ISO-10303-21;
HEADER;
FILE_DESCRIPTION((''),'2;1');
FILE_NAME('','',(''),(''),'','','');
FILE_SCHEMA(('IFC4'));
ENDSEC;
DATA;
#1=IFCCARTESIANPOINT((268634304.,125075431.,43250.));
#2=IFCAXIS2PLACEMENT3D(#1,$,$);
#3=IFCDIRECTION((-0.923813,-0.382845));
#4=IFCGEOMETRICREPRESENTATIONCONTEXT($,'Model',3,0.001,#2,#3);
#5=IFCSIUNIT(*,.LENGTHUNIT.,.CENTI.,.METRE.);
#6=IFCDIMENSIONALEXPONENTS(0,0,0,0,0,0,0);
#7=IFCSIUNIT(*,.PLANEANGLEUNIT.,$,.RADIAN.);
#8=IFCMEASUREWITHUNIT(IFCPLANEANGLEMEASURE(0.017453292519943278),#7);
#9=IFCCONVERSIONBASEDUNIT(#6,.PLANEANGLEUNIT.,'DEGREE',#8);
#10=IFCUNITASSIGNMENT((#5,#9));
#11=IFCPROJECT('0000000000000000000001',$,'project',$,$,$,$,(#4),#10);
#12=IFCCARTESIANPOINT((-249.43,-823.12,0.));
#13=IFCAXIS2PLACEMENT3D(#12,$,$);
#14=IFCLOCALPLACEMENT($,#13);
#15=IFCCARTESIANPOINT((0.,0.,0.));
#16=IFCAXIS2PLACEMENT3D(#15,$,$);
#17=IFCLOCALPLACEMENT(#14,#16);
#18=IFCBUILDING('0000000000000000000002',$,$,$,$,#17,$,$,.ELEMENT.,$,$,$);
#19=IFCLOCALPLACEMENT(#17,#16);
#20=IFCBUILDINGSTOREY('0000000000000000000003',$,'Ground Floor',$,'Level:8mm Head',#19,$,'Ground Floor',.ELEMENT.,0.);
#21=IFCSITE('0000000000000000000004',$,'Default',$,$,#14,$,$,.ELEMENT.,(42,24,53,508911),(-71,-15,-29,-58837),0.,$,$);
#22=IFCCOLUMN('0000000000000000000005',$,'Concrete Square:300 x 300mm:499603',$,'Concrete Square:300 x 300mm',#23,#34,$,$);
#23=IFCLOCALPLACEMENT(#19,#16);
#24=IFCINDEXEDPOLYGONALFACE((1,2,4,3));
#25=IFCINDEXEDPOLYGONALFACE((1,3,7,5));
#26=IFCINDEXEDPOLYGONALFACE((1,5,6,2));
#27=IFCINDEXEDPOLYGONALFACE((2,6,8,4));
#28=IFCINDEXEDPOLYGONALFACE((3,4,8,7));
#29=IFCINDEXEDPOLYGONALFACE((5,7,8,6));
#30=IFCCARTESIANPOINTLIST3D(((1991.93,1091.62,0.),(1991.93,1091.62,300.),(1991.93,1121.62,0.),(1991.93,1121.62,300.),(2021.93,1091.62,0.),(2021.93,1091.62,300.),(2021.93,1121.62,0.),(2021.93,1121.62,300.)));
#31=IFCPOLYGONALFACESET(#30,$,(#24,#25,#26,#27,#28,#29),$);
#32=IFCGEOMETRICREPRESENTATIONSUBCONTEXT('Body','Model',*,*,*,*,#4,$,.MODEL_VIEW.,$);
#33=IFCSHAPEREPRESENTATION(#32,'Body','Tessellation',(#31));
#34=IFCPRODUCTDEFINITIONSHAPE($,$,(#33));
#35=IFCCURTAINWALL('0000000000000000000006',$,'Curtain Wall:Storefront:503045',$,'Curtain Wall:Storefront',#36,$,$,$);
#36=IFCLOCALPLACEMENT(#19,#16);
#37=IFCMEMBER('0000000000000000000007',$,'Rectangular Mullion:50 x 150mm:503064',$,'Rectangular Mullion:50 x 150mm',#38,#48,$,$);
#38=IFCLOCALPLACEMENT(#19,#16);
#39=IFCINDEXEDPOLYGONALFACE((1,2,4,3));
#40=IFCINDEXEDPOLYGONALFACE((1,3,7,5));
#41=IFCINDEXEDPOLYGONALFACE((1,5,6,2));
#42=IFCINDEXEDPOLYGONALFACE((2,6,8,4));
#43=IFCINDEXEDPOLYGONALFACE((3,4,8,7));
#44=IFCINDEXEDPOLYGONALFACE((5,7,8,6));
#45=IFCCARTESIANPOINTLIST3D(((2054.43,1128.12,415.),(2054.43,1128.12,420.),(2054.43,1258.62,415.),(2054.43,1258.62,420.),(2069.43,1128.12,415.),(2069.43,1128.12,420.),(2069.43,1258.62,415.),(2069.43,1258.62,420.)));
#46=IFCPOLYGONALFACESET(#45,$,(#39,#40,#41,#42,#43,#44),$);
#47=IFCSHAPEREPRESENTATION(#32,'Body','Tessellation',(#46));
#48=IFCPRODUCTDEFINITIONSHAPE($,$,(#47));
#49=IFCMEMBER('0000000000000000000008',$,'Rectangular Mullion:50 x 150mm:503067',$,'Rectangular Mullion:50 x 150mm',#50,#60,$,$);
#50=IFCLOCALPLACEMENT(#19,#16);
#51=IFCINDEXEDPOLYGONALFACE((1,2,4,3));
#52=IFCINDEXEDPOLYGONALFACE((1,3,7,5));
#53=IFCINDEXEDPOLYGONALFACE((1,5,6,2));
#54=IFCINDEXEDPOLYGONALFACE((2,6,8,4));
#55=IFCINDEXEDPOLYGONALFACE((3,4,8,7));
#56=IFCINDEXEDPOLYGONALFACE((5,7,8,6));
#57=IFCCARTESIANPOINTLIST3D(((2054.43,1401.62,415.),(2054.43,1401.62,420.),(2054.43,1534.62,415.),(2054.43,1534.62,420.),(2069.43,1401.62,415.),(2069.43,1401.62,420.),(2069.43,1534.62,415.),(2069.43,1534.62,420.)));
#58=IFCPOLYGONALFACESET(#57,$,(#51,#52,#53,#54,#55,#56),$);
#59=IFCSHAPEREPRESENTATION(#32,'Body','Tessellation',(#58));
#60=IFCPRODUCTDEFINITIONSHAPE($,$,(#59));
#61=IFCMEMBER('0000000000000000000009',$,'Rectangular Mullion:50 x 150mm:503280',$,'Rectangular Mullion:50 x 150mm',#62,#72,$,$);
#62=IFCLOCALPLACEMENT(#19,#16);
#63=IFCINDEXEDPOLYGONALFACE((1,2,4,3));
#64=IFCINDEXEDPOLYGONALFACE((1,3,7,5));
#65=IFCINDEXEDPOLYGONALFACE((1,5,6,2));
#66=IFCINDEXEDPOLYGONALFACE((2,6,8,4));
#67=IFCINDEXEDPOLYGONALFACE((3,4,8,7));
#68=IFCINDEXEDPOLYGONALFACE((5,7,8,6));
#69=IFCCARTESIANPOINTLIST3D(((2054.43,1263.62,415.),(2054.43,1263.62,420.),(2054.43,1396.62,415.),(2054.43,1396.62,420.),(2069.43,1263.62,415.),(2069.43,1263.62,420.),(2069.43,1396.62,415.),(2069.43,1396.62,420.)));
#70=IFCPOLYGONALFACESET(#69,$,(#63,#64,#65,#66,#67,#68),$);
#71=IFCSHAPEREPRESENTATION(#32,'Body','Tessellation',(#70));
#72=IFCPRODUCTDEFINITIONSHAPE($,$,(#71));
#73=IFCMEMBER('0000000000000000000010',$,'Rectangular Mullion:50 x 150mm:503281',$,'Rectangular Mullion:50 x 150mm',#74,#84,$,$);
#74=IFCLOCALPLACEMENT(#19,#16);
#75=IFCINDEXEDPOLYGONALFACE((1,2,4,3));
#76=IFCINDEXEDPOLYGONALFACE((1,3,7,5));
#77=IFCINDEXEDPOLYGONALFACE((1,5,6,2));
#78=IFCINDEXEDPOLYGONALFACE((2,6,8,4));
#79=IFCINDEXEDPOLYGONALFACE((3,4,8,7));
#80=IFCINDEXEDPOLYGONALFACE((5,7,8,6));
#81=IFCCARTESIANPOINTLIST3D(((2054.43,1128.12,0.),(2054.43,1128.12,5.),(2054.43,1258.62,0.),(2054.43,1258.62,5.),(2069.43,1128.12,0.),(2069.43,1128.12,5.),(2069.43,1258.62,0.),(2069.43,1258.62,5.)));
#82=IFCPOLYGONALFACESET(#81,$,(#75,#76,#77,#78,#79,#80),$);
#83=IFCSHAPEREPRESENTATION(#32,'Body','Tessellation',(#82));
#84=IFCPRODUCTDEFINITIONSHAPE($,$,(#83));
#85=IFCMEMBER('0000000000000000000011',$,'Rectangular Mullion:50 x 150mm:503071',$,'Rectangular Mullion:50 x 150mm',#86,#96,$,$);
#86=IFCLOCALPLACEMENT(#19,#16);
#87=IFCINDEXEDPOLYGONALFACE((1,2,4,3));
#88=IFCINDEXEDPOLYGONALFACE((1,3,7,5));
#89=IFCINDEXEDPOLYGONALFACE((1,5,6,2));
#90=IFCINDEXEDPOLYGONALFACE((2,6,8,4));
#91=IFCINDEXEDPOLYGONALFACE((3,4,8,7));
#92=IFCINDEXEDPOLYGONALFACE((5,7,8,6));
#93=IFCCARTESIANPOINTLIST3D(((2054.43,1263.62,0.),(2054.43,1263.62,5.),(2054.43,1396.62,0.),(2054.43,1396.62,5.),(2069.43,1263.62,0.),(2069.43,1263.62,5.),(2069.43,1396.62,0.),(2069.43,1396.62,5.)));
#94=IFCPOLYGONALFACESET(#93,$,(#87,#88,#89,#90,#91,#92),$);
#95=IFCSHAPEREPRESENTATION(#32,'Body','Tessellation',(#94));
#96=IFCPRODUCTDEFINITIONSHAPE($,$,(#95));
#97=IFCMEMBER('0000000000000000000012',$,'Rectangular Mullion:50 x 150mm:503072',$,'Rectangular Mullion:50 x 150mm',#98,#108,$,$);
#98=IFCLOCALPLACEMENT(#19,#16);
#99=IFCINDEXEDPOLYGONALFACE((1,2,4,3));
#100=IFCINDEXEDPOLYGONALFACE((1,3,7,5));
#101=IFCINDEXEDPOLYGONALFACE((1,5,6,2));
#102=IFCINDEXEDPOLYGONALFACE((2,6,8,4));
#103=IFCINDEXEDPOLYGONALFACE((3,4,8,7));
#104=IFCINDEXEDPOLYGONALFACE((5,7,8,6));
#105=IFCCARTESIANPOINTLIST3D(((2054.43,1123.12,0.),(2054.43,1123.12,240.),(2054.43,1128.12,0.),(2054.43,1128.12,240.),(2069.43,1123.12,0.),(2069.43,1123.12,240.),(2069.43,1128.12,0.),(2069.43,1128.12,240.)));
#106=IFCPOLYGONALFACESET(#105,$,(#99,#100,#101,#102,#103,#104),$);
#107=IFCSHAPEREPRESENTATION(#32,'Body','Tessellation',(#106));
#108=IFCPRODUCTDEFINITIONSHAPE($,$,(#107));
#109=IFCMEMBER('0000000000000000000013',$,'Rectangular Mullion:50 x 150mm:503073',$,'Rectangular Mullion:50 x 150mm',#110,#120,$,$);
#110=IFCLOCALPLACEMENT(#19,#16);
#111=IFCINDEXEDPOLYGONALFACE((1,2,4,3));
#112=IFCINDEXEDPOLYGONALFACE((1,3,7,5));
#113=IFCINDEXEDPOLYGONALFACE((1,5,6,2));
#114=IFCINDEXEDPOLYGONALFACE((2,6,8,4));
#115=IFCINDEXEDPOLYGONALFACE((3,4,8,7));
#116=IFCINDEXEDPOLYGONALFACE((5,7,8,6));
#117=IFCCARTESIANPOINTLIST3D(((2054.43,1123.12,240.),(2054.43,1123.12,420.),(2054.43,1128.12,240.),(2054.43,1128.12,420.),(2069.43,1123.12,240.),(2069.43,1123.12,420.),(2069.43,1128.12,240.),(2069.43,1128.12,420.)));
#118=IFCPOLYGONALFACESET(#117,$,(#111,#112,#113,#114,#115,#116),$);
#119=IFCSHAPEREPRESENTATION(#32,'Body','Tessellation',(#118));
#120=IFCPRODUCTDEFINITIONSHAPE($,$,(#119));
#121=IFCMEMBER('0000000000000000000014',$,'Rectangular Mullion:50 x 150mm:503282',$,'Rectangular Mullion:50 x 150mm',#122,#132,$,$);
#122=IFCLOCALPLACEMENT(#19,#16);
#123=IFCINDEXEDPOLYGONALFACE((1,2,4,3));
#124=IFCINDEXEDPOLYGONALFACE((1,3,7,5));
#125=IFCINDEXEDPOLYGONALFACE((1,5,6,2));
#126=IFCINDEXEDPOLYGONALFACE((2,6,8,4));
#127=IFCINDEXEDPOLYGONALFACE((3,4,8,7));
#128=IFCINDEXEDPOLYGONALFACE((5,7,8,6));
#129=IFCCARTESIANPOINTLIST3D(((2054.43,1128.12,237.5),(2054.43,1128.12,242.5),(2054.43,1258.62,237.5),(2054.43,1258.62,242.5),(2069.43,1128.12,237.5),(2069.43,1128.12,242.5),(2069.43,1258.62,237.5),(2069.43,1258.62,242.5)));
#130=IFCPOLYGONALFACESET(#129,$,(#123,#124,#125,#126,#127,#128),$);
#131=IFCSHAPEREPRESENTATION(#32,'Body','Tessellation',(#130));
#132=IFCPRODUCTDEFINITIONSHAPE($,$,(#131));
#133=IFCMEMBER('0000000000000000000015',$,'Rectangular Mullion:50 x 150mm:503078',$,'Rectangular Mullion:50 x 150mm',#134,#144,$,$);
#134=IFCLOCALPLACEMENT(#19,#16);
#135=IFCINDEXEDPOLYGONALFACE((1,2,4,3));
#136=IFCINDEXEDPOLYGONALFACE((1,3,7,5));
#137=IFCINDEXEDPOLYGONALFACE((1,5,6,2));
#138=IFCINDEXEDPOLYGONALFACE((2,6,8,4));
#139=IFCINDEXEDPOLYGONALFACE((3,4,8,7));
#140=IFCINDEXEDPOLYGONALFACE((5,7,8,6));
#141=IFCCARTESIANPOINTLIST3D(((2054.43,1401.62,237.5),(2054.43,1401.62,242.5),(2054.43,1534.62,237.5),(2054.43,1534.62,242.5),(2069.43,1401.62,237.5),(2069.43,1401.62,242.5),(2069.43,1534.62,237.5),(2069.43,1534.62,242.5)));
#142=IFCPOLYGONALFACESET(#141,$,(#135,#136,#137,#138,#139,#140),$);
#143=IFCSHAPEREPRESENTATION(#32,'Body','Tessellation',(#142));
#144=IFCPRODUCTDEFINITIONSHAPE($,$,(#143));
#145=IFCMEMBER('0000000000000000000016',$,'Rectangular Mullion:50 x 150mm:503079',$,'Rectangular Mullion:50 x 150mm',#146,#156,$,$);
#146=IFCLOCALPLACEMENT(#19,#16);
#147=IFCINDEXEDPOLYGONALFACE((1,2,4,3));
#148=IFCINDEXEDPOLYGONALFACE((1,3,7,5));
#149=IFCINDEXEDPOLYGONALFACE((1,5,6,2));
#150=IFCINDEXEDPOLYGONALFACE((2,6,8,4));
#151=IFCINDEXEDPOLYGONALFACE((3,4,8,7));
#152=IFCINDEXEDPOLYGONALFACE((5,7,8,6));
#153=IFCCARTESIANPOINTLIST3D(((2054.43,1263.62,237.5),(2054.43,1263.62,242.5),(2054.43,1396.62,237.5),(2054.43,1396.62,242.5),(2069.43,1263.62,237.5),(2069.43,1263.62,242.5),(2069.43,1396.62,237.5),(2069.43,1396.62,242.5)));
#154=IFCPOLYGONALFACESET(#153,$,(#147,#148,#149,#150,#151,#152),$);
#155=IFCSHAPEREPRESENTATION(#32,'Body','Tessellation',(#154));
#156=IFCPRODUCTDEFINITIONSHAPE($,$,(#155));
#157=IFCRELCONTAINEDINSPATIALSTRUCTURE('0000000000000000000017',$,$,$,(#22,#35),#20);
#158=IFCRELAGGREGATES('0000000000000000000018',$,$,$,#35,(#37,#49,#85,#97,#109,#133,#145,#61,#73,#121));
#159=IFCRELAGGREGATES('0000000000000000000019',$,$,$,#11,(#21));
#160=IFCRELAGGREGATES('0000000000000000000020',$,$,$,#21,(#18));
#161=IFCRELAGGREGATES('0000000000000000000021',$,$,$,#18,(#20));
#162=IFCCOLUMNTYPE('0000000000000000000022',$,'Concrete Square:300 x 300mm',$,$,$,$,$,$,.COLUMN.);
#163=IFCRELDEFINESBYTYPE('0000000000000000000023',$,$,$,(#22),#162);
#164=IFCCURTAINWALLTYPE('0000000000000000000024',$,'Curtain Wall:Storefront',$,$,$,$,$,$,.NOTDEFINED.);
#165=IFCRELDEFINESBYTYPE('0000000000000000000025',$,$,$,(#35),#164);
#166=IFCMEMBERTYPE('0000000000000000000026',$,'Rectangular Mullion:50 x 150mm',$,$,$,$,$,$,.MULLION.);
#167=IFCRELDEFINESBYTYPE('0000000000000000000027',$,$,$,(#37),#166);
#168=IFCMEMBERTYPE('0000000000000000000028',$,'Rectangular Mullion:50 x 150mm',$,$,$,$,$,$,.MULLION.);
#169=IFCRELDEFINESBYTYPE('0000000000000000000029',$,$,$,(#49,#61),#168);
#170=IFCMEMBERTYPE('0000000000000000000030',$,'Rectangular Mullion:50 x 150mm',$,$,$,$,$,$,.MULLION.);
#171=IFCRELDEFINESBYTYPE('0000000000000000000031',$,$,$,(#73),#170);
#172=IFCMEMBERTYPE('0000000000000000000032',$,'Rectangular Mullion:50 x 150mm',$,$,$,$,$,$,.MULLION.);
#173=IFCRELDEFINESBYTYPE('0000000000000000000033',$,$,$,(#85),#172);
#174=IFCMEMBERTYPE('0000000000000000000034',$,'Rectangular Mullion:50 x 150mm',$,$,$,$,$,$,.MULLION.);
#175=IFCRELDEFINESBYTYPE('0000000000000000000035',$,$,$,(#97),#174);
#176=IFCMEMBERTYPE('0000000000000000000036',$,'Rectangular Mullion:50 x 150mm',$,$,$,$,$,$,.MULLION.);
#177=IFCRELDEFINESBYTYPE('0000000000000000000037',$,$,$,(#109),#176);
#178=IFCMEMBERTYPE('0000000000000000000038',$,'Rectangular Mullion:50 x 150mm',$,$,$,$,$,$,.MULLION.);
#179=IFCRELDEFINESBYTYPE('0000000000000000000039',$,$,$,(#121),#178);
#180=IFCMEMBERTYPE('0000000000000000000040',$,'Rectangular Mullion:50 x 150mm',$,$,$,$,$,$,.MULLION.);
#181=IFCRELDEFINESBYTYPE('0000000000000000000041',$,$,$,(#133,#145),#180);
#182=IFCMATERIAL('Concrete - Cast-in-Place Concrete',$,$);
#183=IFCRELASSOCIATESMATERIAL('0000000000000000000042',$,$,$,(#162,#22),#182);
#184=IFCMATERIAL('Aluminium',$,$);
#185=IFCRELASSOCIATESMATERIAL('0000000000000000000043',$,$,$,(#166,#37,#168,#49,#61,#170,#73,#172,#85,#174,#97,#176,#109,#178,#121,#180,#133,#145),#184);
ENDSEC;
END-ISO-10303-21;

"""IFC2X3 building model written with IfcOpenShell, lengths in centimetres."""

from ifc_helpers import new_model, entity, si_unit, converted_unit, direction, frame, origin, origin_2d_with_axis, place, context, subcontext, project, spatial, rectangle, extrude, source, transform, mapped, material, type_object, type_shapes, element, aggregate, save


model = new_model("IFC2X3")

# Units and contexts
model_context = context("Model", 3, precision=0.001, world=frame((268634304.0, 125075431.0, 43250.0)), true_north=direction((-0.923813, -0.382845)))
body_context = subcontext(model_context, "Body", "Model", "MODEL_VIEW")
ifc_project = project(units=[si_unit("LENGTHUNIT", "METRE", prefix="CENTI"), converted_unit("PLANEANGLEUNIT", "DEGREE", entity("IfcPlaneAngleMeasure", 0.017453292519943278), si_unit("PLANEANGLEUNIT", "RADIAN"), dimensions=[0, 0, 0, 0, 0, 0, 0])], contexts=[model_context])

# Site, building, storey
site_placement = place(None, frame((-249.43, -823.12, 0.0)))
site = spatial("IfcSite", under=ifc_project, at=site_placement, Name="Default", CompositionType="ELEMENT", RefLatitude=(42, 24, 53, 508911), RefLongitude=(-71, -15, -29, -58837), RefElevation=0.0)
building_placement = place(site_placement, origin())
building = spatial("IfcBuilding", under=site, at=building_placement, CompositionType="ELEMENT")
storey_placement = place(building_placement, origin())
storey = spatial("IfcBuildingStorey", under=building, at=storey_placement, Name="Ground Floor", ObjectType="Level:8mm Head", LongName="Ground Floor", CompositionType="ELEMENT", Elevation=0.0)

# Column
ifc_material_1 = material(Name="Concrete - Cast-in-Place Concrete")
column_type = type_object("IfcColumnType", Name="Concrete Square:300 x 300mm", PredefinedType="COLUMN", material=ifc_material_1)
shared_shape_1 = source(origin(), body_context, "Body", "SweptSolid", [
    extrude(rectangle(XDim=30.0, YDim=30.0, at=origin_2d_with_axis()), frame((0.0, 0.0, 0.0), z_axis=(0.0, 0.0, 1.0), x_axis=(-1.0, 0.0, 0.0)), (0.0, 0.0, 1.0), 300.0),
])
type_shapes(column_type, [shared_shape_1])
column_placement = place(storey_placement, frame((2006.93, 1106.62, 0.0)))
element("IfcColumn", 1, at=column_placement, inside=storey, type_object=column_type, material=ifc_material_1, Name="Concrete Square:300 x 300mm:499603", ObjectType="Concrete Square:300 x 300mm", context=body_context, shape_type="MappedRepresentation", body=[
    mapped(shared_shape_1, transform((0.0, 0.0, 0.0), scale=1.0)),
])

# Curtain wall, members
curtain_wall_type = type_object("IfcCurtainWallType", Name="Curtain Wall:Storefront", PredefinedType="NOTDEFINED")
curtain_wall_placement = place(storey_placement, origin())
curtain_wall = element("IfcCurtainWall", 2, at=curtain_wall_placement, inside=storey, type_object=curtain_wall_type, Name="Curtain Wall:Storefront:503045", ObjectType="Curtain Wall:Storefront")
ifc_material_2 = material(Name="Aluminium")
member_type_1 = type_object("IfcMemberType", Name="Rectangular Mullion:50 x 150mm", PredefinedType="MULLION", material=ifc_material_2)
shared_shape_2 = source(origin(), body_context, "Body", "SweptSolid", [
    extrude(rectangle(XDim=5.0, YDim=15.0, at=origin_2d_with_axis()), frame((-2.5, 0.0, -130.5), z_axis=(0.0, 0.0, 1.0), x_axis=(-1.0, 0.0, 0.0)), (0.0, 0.0, 1.0), 130.5),
])
type_shapes(member_type_1, [shared_shape_2])
member_1_placement = place(curtain_wall_placement, frame((2061.93, 1128.12, 420.0), z_axis=(0.0, -1.0, 0.0), x_axis=(0.0, 0.0, 1.0)))
member_1 = element("IfcMember", 3, at=member_1_placement, type_object=member_type_1, material=ifc_material_2, Name="Rectangular Mullion:50 x 150mm:503064", ObjectType="Rectangular Mullion:50 x 150mm", context=body_context, shape_type="MappedRepresentation", body=[
    mapped(shared_shape_2, transform((0.0, 0.0, 0.0), scale=1.0)),
])
member_type_2 = type_object("IfcMemberType", Name="Rectangular Mullion:50 x 150mm", PredefinedType="MULLION", material=ifc_material_2)
shared_shape_3 = source(origin(), body_context, "Body", "SweptSolid", [
    extrude(rectangle(XDim=5.0, YDim=15.0, at=origin_2d_with_axis()), frame((-2.5, 0.0, -133.0), z_axis=(0.0, 0.0, 1.0), x_axis=(-1.0, 0.0, 0.0)), (0.0, 0.0, 1.0), 133.0),
])
type_shapes(member_type_2, [shared_shape_3])
member_2_placement = place(curtain_wall_placement, frame((2061.93, 1401.62, 420.0), z_axis=(0.0, -1.0, 0.0), x_axis=(0.0, 0.0, 1.0)))
member_2 = element("IfcMember", 4, at=member_2_placement, type_object=member_type_2, material=ifc_material_2, Name="Rectangular Mullion:50 x 150mm:503067", ObjectType="Rectangular Mullion:50 x 150mm", context=body_context, shape_type="MappedRepresentation", body=[
    mapped(shared_shape_3, transform((0.0, 0.0, 0.0), scale=1.0)),
])
member_3_placement = place(curtain_wall_placement, frame((2061.93, 1263.62, 420.0), z_axis=(0.0, -1.0, 0.0), x_axis=(0.0, 0.0, 1.0)))
member_3 = element("IfcMember", 5, at=member_3_placement, type_object=member_type_2, material=ifc_material_2, Name="Rectangular Mullion:50 x 150mm:503280", ObjectType="Rectangular Mullion:50 x 150mm", context=body_context, shape_type="MappedRepresentation", body=[
    mapped(shared_shape_3, transform((0.0, 0.0, 0.0), scale=1.0)),
])
member_type_3 = type_object("IfcMemberType", Name="Rectangular Mullion:50 x 150mm", PredefinedType="MULLION", material=ifc_material_2)
shared_shape_4 = source(origin(), body_context, "Body", "SweptSolid", [
    extrude(rectangle(XDim=5.0, YDim=15.0, at=origin_2d_with_axis()), frame((-2.5, 0.0, -130.5), z_axis=(0.0, 0.0, 1.0), x_axis=(-1.0, 0.0, 0.0)), (0.0, 0.0, 1.0), 130.5),
])
type_shapes(member_type_3, [shared_shape_4])
member_4_placement = place(curtain_wall_placement, frame((2061.93, 1258.62, 0.0), z_axis=(0.0, 1.0, 0.0), x_axis=(0.0, 0.0, -1.0)))
member_4 = element("IfcMember", 6, at=member_4_placement, type_object=member_type_3, material=ifc_material_2, Name="Rectangular Mullion:50 x 150mm:503281", ObjectType="Rectangular Mullion:50 x 150mm", context=body_context, shape_type="MappedRepresentation", body=[
    mapped(shared_shape_4, transform((0.0, 0.0, 0.0), scale=1.0)),
])
member_type_4 = type_object("IfcMemberType", Name="Rectangular Mullion:50 x 150mm", PredefinedType="MULLION", material=ifc_material_2)
shared_shape_5 = source(origin(), body_context, "Body", "SweptSolid", [
    extrude(rectangle(XDim=5.0, YDim=15.0, at=origin_2d_with_axis()), frame((-2.5, 0.0, -133.0), z_axis=(0.0, 0.0, 1.0), x_axis=(-1.0, 0.0, 0.0)), (0.0, 0.0, 1.0), 133.0),
])
type_shapes(member_type_4, [shared_shape_5])
member_5_placement = place(curtain_wall_placement, frame((2061.93, 1396.62, 0.0), z_axis=(0.0, 1.0, 0.0), x_axis=(0.0, 0.0, -1.0)))
member_5 = element("IfcMember", 7, at=member_5_placement, type_object=member_type_4, material=ifc_material_2, Name="Rectangular Mullion:50 x 150mm:503071", ObjectType="Rectangular Mullion:50 x 150mm", context=body_context, shape_type="MappedRepresentation", body=[
    mapped(shared_shape_5, transform((0.0, 0.0, 0.0), scale=1.0)),
])
member_type_5 = type_object("IfcMemberType", Name="Rectangular Mullion:50 x 150mm", PredefinedType="MULLION", material=ifc_material_2)
shared_shape_6 = source(origin(), body_context, "Body", "SweptSolid", [
    extrude(rectangle(XDim=5.0, YDim=15.0, at=origin_2d_with_axis()), frame((-2.5, 0.0, -240.0), z_axis=(0.0, 0.0, 1.0), x_axis=(-1.0, 0.0, 0.0)), (0.0, 0.0, 1.0), 240.0),
])
type_shapes(member_type_5, [shared_shape_6])
member_6_placement = place(curtain_wall_placement, frame((2061.93, 1123.12, 0.0), z_axis=(0.0, 0.0, -1.0), x_axis=(0.0, -1.0, 0.0)))
member_6 = element("IfcMember", 8, at=member_6_placement, type_object=member_type_5, material=ifc_material_2, Name="Rectangular Mullion:50 x 150mm:503072", ObjectType="Rectangular Mullion:50 x 150mm", context=body_context, shape_type="MappedRepresentation", body=[
    mapped(shared_shape_6, transform((0.0, 0.0, 0.0), scale=1.0)),
])
member_type_6 = type_object("IfcMemberType", Name="Rectangular Mullion:50 x 150mm", PredefinedType="MULLION", material=ifc_material_2)
shared_shape_7 = source(origin(), body_context, "Body", "SweptSolid", [
    extrude(rectangle(XDim=5.0, YDim=15.0, at=origin_2d_with_axis()), frame((-2.5, 0.0, -180.0), z_axis=(0.0, 0.0, 1.0), x_axis=(-1.0, 0.0, 0.0)), (0.0, 0.0, 1.0), 180.0),
])
type_shapes(member_type_6, [shared_shape_7])
member_7_placement = place(curtain_wall_placement, frame((2061.93, 1123.12, 240.0), z_axis=(0.0, 0.0, -1.0), x_axis=(0.0, -1.0, 0.0)))
member_7 = element("IfcMember", 9, at=member_7_placement, type_object=member_type_6, material=ifc_material_2, Name="Rectangular Mullion:50 x 150mm:503073", ObjectType="Rectangular Mullion:50 x 150mm", context=body_context, shape_type="MappedRepresentation", body=[
    mapped(shared_shape_7, transform((0.0, 0.0, 0.0), scale=1.0)),
])
member_type_7 = type_object("IfcMemberType", Name="Rectangular Mullion:50 x 150mm", PredefinedType="MULLION", material=ifc_material_2)
shared_shape_8 = source(origin(), body_context, "Body", "SweptSolid", [
    extrude(rectangle(XDim=5.0, YDim=15.0, at=origin_2d_with_axis()), frame((0.0, 0.0, -130.5), z_axis=(0.0, 0.0, 1.0), x_axis=(-1.0, 0.0, 0.0)), (0.0, 0.0, 1.0), 130.5),
])
type_shapes(member_type_7, [shared_shape_8])
member_8_placement = place(curtain_wall_placement, frame((2061.93, 1128.12, 240.0), z_axis=(0.0, -1.0, 0.0), x_axis=(0.0, 0.0, 1.0)))
member_8 = element("IfcMember", 10, at=member_8_placement, type_object=member_type_7, material=ifc_material_2, Name="Rectangular Mullion:50 x 150mm:503282", ObjectType="Rectangular Mullion:50 x 150mm", context=body_context, shape_type="MappedRepresentation", body=[
    mapped(shared_shape_8, transform((0.0, 0.0, 0.0), scale=1.0)),
])
member_type_8 = type_object("IfcMemberType", Name="Rectangular Mullion:50 x 150mm", PredefinedType="MULLION", material=ifc_material_2)
shared_shape_9 = source(origin(), body_context, "Body", "SweptSolid", [
    extrude(rectangle(XDim=5.0, YDim=15.0, at=origin_2d_with_axis()), frame((0.0, 0.0, -133.0), z_axis=(0.0, 0.0, 1.0), x_axis=(-1.0, 0.0, 0.0)), (0.0, 0.0, 1.0), 133.0),
])
type_shapes(member_type_8, [shared_shape_9])
member_9_placement = place(curtain_wall_placement, frame((2061.93, 1401.62, 240.0), z_axis=(0.0, -1.0, 0.0), x_axis=(0.0, 0.0, 1.0)))
member_9 = element("IfcMember", 11, at=member_9_placement, type_object=member_type_8, material=ifc_material_2, Name="Rectangular Mullion:50 x 150mm:503078", ObjectType="Rectangular Mullion:50 x 150mm", context=body_context, shape_type="MappedRepresentation", body=[
    mapped(shared_shape_9, transform((0.0, 0.0, 0.0), scale=1.0)),
])
member_10_placement = place(curtain_wall_placement, frame((2061.93, 1263.62, 240.0), z_axis=(0.0, -1.0, 0.0), x_axis=(0.0, 0.0, 1.0)))
member_10 = element("IfcMember", 12, at=member_10_placement, type_object=member_type_8, material=ifc_material_2, Name="Rectangular Mullion:50 x 150mm:503079", ObjectType="Rectangular Mullion:50 x 150mm", context=body_context, shape_type="MappedRepresentation", body=[
    mapped(shared_shape_9, transform((0.0, 0.0, 0.0), scale=1.0)),
])
aggregate(curtain_wall, [member_1, member_2, member_5, member_6, member_7, member_9, member_10, member_3, member_4, member_8])

save(model, "model.ifc")
